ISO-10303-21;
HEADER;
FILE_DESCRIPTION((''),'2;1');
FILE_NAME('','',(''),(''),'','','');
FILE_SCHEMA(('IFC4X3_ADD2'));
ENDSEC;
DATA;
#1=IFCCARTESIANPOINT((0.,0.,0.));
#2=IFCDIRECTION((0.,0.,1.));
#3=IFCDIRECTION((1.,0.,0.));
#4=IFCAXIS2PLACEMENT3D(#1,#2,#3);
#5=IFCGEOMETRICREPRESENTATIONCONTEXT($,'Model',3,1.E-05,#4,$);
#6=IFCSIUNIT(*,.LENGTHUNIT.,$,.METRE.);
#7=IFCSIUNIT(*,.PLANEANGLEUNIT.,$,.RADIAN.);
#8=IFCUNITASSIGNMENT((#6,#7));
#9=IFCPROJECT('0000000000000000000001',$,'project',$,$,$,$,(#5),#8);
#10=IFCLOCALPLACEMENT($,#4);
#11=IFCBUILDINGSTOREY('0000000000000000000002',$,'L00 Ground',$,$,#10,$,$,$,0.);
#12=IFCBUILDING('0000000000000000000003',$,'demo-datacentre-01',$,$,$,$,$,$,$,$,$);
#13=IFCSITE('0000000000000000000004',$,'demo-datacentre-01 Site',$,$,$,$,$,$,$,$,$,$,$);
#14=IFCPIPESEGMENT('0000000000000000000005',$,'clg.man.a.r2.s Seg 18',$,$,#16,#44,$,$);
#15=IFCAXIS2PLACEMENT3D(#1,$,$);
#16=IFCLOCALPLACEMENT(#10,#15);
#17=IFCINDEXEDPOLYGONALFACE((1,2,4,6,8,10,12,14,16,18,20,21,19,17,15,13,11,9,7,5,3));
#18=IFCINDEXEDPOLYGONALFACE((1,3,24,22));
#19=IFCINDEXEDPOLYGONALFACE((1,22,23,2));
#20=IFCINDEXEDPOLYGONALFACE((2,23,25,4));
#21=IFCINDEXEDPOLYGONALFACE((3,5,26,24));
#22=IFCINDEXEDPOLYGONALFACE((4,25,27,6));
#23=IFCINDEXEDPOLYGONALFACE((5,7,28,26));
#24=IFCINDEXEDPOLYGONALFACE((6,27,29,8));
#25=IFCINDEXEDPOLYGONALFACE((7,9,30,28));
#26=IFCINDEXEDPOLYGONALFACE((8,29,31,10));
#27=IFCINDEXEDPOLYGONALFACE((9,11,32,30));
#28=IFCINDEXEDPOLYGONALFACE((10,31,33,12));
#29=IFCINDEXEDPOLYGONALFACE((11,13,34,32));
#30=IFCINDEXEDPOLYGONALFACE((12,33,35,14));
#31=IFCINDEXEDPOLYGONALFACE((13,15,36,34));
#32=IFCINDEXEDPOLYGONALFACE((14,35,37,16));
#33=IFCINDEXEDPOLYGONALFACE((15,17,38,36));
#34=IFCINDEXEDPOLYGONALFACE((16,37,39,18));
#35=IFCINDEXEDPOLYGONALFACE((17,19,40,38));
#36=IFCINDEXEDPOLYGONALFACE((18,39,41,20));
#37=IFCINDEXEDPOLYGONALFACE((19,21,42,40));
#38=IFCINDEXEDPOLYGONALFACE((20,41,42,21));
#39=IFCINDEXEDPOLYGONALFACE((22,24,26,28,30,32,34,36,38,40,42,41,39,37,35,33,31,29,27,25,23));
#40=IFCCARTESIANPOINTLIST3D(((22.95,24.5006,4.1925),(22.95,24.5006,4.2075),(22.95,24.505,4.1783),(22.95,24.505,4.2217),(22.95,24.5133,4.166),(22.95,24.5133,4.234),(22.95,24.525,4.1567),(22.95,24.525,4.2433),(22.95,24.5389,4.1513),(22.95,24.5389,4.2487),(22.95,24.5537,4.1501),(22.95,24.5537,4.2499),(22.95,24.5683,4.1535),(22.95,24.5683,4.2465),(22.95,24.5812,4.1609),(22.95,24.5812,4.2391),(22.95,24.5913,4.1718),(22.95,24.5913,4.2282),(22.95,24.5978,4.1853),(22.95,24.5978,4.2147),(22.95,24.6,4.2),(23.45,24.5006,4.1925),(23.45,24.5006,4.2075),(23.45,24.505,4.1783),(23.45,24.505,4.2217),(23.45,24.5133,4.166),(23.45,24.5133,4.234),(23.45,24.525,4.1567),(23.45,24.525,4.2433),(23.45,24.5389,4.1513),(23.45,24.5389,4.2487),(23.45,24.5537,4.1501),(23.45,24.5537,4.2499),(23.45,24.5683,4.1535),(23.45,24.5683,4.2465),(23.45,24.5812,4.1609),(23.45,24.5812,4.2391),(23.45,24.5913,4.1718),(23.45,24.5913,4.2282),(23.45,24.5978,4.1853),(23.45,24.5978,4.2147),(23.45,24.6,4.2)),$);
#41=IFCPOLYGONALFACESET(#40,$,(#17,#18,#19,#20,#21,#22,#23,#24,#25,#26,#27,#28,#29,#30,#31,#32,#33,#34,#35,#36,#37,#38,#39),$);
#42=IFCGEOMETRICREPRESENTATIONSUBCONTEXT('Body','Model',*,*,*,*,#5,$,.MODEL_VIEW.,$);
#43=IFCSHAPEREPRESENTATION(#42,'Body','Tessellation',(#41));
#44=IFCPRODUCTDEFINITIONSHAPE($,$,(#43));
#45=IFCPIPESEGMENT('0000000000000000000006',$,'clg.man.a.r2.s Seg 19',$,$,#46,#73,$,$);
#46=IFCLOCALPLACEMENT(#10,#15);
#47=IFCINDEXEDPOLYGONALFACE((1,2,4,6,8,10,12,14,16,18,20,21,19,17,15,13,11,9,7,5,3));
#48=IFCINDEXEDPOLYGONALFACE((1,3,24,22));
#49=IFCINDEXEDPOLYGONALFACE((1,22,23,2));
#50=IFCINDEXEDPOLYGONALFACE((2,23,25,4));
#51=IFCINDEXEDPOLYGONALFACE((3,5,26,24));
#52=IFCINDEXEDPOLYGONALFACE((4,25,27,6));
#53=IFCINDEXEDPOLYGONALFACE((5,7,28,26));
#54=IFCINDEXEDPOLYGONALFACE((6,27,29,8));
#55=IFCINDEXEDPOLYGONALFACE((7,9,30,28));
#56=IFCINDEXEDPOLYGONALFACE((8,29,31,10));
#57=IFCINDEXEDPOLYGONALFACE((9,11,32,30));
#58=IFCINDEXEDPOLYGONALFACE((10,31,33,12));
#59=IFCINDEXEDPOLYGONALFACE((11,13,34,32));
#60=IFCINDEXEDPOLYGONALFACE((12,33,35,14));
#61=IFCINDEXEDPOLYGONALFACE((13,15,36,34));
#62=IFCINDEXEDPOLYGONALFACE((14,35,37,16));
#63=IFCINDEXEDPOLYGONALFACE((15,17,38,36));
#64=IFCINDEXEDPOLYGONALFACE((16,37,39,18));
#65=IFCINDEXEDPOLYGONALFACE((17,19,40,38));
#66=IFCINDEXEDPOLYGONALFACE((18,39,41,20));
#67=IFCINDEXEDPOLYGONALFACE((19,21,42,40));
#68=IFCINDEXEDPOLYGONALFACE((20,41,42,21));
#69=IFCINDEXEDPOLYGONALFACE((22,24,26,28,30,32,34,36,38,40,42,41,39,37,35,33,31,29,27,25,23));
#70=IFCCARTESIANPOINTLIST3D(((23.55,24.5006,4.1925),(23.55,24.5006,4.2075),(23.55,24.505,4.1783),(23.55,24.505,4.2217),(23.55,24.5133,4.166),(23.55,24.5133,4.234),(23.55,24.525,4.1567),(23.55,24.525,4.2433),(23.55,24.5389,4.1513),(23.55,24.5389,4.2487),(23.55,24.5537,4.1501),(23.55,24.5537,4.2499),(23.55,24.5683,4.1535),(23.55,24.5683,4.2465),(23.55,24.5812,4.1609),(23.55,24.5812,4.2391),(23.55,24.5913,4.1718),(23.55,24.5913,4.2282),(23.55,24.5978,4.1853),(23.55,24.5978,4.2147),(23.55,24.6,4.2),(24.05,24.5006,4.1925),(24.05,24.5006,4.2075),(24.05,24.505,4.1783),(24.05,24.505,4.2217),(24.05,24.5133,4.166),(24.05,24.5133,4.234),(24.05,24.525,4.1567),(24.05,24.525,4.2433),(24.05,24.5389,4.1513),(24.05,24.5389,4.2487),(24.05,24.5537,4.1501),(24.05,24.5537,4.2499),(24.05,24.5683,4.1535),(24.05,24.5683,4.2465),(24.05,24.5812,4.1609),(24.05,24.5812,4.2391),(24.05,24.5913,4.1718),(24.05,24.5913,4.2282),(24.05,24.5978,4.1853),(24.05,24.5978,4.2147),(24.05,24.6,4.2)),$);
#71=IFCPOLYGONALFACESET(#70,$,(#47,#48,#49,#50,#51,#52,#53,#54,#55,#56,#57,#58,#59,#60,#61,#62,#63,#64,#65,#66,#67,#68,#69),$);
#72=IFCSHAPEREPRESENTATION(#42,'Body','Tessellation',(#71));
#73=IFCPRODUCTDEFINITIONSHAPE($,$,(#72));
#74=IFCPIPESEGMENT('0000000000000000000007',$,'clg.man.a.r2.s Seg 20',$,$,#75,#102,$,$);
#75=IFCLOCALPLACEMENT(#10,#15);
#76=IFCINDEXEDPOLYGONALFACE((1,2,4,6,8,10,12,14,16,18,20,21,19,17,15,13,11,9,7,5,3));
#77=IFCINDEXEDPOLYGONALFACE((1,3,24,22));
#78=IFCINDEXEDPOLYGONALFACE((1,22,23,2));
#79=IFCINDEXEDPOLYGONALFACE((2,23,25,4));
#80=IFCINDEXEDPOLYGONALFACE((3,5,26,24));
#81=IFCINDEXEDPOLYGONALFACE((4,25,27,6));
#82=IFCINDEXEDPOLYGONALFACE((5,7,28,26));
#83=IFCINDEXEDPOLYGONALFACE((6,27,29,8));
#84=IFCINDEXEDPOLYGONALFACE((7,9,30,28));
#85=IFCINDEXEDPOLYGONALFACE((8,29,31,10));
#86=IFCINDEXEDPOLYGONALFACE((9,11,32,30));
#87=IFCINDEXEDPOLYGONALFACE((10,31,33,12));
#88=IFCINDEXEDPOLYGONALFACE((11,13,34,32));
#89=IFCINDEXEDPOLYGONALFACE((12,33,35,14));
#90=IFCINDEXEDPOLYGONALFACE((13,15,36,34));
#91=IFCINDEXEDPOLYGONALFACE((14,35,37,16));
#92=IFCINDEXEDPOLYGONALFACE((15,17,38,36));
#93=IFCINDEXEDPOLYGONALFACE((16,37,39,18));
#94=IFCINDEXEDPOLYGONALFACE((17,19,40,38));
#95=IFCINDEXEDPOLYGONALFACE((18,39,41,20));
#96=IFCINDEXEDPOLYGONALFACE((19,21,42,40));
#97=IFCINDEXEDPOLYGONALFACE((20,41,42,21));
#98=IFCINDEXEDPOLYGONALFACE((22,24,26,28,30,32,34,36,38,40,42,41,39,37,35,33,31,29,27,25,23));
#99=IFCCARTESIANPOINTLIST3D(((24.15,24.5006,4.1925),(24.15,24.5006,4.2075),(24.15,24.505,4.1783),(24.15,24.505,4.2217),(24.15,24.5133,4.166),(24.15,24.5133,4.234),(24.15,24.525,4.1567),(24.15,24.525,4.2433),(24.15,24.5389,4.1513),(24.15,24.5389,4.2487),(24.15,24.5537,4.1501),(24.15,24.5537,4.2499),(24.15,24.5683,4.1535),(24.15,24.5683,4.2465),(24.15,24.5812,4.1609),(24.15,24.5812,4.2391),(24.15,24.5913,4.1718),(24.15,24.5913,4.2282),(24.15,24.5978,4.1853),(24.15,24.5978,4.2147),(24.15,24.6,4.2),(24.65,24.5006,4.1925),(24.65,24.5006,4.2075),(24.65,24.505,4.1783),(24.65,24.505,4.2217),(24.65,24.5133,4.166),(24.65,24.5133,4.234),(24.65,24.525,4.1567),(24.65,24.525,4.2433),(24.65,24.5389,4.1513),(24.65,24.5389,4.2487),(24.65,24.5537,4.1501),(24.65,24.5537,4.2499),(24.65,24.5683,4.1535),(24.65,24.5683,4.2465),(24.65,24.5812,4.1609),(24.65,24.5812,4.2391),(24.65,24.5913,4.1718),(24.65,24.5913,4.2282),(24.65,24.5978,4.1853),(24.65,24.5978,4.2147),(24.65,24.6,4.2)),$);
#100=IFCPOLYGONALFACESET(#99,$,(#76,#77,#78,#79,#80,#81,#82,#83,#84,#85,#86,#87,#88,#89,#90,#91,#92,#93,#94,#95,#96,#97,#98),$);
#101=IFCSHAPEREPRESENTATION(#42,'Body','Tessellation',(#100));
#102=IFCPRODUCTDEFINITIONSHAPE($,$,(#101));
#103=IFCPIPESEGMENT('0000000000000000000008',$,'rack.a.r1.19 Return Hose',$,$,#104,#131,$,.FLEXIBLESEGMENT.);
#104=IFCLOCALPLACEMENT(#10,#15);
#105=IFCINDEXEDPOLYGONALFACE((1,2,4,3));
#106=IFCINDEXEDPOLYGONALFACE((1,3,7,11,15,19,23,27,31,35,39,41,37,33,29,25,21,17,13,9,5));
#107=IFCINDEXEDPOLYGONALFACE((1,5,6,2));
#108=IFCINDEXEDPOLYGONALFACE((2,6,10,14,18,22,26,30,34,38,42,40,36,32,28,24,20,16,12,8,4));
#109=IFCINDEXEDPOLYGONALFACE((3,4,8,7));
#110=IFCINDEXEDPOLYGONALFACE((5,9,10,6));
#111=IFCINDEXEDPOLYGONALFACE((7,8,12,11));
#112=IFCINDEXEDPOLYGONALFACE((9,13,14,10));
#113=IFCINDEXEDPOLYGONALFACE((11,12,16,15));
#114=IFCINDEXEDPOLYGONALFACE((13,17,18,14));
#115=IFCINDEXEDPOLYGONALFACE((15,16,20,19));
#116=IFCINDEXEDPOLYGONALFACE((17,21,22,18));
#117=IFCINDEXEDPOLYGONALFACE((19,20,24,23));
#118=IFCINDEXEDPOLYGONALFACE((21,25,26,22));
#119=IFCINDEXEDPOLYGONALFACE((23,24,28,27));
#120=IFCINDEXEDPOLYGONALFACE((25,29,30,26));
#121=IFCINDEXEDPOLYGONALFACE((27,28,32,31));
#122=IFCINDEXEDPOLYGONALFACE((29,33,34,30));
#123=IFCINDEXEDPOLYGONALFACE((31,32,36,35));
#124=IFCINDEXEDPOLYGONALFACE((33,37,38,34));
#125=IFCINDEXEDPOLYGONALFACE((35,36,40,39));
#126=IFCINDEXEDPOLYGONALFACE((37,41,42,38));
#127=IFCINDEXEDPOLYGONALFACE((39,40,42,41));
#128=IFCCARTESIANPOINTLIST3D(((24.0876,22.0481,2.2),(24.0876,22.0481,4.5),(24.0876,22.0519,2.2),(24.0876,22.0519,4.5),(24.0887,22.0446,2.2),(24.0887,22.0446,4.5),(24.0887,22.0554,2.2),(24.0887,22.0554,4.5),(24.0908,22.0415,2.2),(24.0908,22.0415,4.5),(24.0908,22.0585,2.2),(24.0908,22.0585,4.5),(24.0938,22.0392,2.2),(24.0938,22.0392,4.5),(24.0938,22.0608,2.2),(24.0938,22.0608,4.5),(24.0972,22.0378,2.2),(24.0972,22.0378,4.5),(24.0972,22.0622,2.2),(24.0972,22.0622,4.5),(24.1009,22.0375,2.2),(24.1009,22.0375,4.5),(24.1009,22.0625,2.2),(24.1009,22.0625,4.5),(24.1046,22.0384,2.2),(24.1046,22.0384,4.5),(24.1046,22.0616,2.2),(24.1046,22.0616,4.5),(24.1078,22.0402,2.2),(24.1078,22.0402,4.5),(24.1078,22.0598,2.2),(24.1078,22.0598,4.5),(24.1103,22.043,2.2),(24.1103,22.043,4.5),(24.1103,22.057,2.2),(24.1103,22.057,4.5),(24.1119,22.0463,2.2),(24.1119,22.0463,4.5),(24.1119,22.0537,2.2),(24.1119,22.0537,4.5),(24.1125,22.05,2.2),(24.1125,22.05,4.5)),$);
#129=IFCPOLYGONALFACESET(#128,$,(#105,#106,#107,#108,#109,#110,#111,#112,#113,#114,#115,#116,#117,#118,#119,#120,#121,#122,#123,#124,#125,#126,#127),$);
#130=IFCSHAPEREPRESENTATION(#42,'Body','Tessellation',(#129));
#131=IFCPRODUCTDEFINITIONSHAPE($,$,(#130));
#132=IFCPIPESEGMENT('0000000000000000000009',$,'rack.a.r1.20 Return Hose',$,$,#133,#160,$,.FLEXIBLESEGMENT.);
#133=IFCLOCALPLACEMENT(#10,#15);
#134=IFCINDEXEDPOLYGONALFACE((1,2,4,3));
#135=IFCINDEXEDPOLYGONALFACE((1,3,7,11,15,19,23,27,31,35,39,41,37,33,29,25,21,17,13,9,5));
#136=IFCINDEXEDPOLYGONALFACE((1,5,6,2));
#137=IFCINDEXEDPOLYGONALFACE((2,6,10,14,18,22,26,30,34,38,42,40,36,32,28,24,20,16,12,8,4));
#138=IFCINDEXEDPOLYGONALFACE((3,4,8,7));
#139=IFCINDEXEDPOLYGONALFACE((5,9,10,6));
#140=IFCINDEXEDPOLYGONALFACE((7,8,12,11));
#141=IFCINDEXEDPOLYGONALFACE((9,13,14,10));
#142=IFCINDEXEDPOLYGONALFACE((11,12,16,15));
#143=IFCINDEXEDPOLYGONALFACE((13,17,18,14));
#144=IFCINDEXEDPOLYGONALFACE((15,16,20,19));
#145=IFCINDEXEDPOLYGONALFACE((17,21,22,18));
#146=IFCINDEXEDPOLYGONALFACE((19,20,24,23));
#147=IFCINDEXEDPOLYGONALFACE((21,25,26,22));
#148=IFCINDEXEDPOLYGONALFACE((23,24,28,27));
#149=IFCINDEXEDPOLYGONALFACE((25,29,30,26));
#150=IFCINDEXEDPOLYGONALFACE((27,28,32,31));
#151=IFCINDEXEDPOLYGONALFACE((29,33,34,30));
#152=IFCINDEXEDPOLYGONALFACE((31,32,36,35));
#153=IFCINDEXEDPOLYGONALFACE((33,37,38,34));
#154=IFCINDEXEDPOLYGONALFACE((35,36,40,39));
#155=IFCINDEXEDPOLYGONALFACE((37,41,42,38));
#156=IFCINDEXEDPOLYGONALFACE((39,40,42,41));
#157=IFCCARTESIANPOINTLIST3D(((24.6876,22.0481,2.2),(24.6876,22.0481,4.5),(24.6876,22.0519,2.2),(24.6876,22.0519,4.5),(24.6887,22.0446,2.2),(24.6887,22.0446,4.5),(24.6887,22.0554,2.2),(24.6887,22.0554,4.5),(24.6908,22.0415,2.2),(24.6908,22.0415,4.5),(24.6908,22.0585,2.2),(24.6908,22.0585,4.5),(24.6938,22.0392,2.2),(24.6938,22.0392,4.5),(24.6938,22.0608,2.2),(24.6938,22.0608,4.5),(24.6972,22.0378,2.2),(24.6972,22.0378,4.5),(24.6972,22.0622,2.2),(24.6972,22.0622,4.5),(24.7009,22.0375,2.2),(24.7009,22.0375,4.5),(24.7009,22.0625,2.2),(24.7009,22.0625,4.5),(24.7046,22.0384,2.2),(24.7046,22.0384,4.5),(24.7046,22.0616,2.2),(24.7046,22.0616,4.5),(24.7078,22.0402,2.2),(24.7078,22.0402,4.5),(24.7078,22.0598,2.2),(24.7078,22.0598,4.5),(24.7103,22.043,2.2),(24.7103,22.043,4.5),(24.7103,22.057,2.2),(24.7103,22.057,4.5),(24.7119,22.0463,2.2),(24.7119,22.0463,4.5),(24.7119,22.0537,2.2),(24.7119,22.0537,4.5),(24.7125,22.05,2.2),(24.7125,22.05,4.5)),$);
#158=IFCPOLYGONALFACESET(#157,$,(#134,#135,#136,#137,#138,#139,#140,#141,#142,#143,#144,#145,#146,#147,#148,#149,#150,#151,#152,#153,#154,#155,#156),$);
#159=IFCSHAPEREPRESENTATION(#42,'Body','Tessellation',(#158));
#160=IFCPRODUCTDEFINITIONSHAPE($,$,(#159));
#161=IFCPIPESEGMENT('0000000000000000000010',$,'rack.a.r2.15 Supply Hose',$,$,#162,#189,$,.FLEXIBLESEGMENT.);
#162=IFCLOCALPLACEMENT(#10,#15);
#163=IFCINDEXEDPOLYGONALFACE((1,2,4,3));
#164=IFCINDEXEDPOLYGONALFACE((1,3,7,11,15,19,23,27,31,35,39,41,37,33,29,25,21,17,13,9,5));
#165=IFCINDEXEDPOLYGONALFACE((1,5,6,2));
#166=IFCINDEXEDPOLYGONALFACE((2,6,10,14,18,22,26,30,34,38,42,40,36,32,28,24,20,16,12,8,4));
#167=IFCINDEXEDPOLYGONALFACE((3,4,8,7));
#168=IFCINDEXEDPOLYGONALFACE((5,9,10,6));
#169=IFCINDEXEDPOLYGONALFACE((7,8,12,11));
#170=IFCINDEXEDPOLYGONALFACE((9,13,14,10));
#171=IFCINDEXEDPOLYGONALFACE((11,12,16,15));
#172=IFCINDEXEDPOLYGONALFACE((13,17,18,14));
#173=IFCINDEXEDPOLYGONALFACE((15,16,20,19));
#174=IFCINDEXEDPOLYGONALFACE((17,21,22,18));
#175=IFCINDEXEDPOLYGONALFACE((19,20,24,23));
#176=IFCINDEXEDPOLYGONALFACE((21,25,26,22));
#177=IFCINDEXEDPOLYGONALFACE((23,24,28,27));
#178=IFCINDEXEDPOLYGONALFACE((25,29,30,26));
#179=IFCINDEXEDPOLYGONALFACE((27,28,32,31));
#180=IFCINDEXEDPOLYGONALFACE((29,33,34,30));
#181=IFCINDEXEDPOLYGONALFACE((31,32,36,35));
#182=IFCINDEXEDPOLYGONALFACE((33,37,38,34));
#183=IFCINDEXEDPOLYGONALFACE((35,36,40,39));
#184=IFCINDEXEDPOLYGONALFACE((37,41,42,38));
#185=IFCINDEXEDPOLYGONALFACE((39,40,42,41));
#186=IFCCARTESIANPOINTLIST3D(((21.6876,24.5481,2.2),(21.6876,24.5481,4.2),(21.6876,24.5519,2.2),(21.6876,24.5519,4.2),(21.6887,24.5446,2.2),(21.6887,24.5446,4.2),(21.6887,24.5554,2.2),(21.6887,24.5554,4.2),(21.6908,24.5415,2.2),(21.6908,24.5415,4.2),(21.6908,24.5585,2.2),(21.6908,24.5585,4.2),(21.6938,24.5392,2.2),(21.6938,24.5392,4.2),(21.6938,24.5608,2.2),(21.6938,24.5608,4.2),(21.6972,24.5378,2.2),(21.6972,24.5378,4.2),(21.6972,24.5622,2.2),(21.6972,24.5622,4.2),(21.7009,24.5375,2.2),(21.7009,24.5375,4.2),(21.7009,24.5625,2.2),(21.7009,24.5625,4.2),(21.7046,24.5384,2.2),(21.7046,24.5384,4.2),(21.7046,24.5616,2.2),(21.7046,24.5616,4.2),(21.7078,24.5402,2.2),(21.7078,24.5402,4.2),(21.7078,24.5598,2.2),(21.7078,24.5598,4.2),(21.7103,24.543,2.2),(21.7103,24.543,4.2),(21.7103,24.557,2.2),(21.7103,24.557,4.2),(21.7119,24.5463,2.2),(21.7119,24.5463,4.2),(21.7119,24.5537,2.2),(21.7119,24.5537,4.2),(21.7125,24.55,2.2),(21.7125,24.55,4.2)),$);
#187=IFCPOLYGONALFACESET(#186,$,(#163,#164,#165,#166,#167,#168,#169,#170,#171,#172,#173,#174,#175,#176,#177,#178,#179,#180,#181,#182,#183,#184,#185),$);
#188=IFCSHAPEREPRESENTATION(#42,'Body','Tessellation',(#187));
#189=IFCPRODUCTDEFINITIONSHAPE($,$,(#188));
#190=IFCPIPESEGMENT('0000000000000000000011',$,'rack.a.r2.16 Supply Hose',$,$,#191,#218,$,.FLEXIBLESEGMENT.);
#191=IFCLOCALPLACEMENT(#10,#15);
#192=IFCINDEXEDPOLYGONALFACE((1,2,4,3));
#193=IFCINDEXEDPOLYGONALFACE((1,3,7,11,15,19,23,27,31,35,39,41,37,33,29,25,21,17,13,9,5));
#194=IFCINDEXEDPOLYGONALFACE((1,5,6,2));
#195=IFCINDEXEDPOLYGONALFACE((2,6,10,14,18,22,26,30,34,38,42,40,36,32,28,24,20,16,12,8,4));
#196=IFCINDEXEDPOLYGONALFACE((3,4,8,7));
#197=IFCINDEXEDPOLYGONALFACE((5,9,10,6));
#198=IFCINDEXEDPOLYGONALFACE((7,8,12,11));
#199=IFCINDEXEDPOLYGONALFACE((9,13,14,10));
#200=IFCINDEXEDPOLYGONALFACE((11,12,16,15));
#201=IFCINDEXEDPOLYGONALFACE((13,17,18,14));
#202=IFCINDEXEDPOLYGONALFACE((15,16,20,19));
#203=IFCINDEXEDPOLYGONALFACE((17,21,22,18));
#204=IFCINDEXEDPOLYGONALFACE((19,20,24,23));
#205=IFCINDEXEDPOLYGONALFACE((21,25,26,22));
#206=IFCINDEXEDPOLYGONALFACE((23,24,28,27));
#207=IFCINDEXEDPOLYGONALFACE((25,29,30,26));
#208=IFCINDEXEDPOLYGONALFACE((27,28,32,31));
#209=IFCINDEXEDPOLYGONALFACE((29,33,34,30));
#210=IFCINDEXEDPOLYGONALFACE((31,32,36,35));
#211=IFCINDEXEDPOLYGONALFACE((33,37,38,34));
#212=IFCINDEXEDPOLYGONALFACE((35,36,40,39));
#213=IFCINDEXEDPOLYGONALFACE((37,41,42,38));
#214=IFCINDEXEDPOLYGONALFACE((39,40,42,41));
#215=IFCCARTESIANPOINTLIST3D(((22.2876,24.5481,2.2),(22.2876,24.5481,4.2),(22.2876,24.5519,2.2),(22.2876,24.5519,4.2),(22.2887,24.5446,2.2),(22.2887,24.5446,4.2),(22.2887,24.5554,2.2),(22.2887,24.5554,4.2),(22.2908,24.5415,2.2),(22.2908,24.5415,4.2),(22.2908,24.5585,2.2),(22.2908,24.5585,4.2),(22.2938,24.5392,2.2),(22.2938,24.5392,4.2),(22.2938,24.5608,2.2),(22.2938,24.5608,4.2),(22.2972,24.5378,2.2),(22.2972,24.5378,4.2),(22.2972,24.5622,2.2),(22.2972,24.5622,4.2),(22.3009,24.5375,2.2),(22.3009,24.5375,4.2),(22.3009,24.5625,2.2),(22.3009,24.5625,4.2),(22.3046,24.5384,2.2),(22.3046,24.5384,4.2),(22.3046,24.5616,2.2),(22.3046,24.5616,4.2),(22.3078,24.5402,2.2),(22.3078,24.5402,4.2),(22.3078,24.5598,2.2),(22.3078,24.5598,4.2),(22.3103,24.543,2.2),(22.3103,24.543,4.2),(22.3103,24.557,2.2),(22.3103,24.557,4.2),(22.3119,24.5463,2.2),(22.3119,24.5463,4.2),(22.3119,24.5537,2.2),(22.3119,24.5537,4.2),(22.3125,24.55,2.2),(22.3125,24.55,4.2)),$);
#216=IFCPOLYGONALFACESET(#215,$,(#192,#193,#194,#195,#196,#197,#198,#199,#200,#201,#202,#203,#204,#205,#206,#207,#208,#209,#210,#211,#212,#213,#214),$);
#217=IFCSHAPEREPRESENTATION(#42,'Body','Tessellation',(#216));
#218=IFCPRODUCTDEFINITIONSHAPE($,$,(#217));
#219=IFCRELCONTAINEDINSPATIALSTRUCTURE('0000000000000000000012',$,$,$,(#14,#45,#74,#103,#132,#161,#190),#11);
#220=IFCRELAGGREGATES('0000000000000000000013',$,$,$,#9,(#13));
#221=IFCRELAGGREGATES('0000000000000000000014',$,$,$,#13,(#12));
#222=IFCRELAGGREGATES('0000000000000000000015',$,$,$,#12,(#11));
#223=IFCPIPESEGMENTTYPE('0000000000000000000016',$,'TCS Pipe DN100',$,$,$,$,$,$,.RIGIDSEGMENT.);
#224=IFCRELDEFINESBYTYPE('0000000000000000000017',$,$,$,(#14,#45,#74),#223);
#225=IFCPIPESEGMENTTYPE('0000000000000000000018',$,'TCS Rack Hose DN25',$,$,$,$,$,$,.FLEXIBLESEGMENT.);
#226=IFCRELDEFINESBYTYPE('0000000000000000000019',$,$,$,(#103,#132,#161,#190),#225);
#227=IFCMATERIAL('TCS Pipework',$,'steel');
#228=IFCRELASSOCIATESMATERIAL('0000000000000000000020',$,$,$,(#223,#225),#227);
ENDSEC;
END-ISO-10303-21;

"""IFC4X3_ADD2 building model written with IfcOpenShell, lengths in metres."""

from ifc_helpers import new_model, si_unit, frame, origin_with_axes, place, context, subcontext, project, spatial, circle, extrude, material, type_object, element, save


model = new_model("IFC4X3_ADD2")

# Units and contexts
model_context = context("Model", 3, precision=1e-05, world=origin_with_axes())
body_context = subcontext(model_context, "Body", "Model", "MODEL_VIEW")
ifc_project = project(units=[si_unit("LENGTHUNIT", "METRE"), si_unit("PLANEANGLEUNIT", "RADIAN")], contexts=[model_context])

# Site, building, storey
site = spatial("IfcSite", under=ifc_project, Name="demo-datacentre-01 Site")
building = spatial("IfcBuilding", under=site, Name="demo-datacentre-01")
storey_placement = place(None, origin_with_axes())
storey = spatial("IfcBuildingStorey", under=building, at=storey_placement, Name="L00 Ground", Elevation=0.0)

# Shared definitions
ifc_material = material(Name="TCS Pipework", Category="steel")

# Pipe segments
pipe_segment_type_1 = type_object("IfcPipeSegmentType", Name="TCS Pipe DN100", PredefinedType="RIGIDSEGMENT", material=ifc_material)
for number, where, z_axis, x_axis, name in (
    (1, (22.95, 24.55, 4.2), (1.0, 0.0, 0.0), (0.0, 1.0, 0.0), "clg.man.a.r2.s Seg 18"),
    (2, (23.55, 24.55, 4.2), (1.0, 0.0, 0.0), (0.0, 1.0, 0.0), "clg.man.a.r2.s Seg 19"),
    (3, (24.15, 24.55, 4.2), (1.0, 0.0, 0.0), (0.0, 1.0, 0.0), "clg.man.a.r2.s Seg 20"),
):
    element("IfcPipeSegment", number, at=place(storey_placement, frame(where, z_axis=z_axis, x_axis=x_axis)), inside=storey, type_object=pipe_segment_type_1, Name=name, context=body_context, shape_type="SweptSolid", body=[
        extrude(circle(Radius=0.05), origin_with_axes(), (0.0, 0.0, 1.0), 0.5),
    ])
pipe_segment_type_2 = type_object("IfcPipeSegmentType", Name="TCS Rack Hose DN25", PredefinedType="FLEXIBLESEGMENT", material=ifc_material)
for number, where, z_axis, x_axis, name in (
    (4, (24.1, 22.05, 4.5), (0.0, 0.0, -1.0), (1.0, 0.0, 0.0), "rack.a.r1.19 Return Hose"),
    (5, (24.7, 22.05, 4.5), (0.0, 0.0, -1.0), (1.0, 0.0, 0.0), "rack.a.r1.20 Return Hose"),
):
    element("IfcPipeSegment", number, at=place(storey_placement, frame(where, z_axis=z_axis, x_axis=x_axis)), inside=storey, type_object=pipe_segment_type_2, Name=name, PredefinedType="FLEXIBLESEGMENT", context=body_context, shape_type="SweptSolid", body=[
        extrude(circle(Radius=0.0125), origin_with_axes(), (0.0, 0.0, 1.0), 2.3),
    ])
for number, where, z_axis, x_axis, name in (
    (6, (21.7, 24.55, 4.2), (0.0, 0.0, -1.0), (1.0, 0.0, 0.0), "rack.a.r2.15 Supply Hose"),
    (7, (22.3, 24.55, 4.2), (0.0, 0.0, -1.0), (1.0, 0.0, 0.0), "rack.a.r2.16 Supply Hose"),
):
    element("IfcPipeSegment", number, at=place(storey_placement, frame(where, z_axis=z_axis, x_axis=x_axis)), inside=storey, type_object=pipe_segment_type_2, Name=name, PredefinedType="FLEXIBLESEGMENT", context=body_context, shape_type="SweptSolid", body=[
        extrude(circle(Radius=0.0125), origin_with_axes(), (0.0, 0.0, 1.0), 2.0),
    ])

save(model, "model.ifc")
